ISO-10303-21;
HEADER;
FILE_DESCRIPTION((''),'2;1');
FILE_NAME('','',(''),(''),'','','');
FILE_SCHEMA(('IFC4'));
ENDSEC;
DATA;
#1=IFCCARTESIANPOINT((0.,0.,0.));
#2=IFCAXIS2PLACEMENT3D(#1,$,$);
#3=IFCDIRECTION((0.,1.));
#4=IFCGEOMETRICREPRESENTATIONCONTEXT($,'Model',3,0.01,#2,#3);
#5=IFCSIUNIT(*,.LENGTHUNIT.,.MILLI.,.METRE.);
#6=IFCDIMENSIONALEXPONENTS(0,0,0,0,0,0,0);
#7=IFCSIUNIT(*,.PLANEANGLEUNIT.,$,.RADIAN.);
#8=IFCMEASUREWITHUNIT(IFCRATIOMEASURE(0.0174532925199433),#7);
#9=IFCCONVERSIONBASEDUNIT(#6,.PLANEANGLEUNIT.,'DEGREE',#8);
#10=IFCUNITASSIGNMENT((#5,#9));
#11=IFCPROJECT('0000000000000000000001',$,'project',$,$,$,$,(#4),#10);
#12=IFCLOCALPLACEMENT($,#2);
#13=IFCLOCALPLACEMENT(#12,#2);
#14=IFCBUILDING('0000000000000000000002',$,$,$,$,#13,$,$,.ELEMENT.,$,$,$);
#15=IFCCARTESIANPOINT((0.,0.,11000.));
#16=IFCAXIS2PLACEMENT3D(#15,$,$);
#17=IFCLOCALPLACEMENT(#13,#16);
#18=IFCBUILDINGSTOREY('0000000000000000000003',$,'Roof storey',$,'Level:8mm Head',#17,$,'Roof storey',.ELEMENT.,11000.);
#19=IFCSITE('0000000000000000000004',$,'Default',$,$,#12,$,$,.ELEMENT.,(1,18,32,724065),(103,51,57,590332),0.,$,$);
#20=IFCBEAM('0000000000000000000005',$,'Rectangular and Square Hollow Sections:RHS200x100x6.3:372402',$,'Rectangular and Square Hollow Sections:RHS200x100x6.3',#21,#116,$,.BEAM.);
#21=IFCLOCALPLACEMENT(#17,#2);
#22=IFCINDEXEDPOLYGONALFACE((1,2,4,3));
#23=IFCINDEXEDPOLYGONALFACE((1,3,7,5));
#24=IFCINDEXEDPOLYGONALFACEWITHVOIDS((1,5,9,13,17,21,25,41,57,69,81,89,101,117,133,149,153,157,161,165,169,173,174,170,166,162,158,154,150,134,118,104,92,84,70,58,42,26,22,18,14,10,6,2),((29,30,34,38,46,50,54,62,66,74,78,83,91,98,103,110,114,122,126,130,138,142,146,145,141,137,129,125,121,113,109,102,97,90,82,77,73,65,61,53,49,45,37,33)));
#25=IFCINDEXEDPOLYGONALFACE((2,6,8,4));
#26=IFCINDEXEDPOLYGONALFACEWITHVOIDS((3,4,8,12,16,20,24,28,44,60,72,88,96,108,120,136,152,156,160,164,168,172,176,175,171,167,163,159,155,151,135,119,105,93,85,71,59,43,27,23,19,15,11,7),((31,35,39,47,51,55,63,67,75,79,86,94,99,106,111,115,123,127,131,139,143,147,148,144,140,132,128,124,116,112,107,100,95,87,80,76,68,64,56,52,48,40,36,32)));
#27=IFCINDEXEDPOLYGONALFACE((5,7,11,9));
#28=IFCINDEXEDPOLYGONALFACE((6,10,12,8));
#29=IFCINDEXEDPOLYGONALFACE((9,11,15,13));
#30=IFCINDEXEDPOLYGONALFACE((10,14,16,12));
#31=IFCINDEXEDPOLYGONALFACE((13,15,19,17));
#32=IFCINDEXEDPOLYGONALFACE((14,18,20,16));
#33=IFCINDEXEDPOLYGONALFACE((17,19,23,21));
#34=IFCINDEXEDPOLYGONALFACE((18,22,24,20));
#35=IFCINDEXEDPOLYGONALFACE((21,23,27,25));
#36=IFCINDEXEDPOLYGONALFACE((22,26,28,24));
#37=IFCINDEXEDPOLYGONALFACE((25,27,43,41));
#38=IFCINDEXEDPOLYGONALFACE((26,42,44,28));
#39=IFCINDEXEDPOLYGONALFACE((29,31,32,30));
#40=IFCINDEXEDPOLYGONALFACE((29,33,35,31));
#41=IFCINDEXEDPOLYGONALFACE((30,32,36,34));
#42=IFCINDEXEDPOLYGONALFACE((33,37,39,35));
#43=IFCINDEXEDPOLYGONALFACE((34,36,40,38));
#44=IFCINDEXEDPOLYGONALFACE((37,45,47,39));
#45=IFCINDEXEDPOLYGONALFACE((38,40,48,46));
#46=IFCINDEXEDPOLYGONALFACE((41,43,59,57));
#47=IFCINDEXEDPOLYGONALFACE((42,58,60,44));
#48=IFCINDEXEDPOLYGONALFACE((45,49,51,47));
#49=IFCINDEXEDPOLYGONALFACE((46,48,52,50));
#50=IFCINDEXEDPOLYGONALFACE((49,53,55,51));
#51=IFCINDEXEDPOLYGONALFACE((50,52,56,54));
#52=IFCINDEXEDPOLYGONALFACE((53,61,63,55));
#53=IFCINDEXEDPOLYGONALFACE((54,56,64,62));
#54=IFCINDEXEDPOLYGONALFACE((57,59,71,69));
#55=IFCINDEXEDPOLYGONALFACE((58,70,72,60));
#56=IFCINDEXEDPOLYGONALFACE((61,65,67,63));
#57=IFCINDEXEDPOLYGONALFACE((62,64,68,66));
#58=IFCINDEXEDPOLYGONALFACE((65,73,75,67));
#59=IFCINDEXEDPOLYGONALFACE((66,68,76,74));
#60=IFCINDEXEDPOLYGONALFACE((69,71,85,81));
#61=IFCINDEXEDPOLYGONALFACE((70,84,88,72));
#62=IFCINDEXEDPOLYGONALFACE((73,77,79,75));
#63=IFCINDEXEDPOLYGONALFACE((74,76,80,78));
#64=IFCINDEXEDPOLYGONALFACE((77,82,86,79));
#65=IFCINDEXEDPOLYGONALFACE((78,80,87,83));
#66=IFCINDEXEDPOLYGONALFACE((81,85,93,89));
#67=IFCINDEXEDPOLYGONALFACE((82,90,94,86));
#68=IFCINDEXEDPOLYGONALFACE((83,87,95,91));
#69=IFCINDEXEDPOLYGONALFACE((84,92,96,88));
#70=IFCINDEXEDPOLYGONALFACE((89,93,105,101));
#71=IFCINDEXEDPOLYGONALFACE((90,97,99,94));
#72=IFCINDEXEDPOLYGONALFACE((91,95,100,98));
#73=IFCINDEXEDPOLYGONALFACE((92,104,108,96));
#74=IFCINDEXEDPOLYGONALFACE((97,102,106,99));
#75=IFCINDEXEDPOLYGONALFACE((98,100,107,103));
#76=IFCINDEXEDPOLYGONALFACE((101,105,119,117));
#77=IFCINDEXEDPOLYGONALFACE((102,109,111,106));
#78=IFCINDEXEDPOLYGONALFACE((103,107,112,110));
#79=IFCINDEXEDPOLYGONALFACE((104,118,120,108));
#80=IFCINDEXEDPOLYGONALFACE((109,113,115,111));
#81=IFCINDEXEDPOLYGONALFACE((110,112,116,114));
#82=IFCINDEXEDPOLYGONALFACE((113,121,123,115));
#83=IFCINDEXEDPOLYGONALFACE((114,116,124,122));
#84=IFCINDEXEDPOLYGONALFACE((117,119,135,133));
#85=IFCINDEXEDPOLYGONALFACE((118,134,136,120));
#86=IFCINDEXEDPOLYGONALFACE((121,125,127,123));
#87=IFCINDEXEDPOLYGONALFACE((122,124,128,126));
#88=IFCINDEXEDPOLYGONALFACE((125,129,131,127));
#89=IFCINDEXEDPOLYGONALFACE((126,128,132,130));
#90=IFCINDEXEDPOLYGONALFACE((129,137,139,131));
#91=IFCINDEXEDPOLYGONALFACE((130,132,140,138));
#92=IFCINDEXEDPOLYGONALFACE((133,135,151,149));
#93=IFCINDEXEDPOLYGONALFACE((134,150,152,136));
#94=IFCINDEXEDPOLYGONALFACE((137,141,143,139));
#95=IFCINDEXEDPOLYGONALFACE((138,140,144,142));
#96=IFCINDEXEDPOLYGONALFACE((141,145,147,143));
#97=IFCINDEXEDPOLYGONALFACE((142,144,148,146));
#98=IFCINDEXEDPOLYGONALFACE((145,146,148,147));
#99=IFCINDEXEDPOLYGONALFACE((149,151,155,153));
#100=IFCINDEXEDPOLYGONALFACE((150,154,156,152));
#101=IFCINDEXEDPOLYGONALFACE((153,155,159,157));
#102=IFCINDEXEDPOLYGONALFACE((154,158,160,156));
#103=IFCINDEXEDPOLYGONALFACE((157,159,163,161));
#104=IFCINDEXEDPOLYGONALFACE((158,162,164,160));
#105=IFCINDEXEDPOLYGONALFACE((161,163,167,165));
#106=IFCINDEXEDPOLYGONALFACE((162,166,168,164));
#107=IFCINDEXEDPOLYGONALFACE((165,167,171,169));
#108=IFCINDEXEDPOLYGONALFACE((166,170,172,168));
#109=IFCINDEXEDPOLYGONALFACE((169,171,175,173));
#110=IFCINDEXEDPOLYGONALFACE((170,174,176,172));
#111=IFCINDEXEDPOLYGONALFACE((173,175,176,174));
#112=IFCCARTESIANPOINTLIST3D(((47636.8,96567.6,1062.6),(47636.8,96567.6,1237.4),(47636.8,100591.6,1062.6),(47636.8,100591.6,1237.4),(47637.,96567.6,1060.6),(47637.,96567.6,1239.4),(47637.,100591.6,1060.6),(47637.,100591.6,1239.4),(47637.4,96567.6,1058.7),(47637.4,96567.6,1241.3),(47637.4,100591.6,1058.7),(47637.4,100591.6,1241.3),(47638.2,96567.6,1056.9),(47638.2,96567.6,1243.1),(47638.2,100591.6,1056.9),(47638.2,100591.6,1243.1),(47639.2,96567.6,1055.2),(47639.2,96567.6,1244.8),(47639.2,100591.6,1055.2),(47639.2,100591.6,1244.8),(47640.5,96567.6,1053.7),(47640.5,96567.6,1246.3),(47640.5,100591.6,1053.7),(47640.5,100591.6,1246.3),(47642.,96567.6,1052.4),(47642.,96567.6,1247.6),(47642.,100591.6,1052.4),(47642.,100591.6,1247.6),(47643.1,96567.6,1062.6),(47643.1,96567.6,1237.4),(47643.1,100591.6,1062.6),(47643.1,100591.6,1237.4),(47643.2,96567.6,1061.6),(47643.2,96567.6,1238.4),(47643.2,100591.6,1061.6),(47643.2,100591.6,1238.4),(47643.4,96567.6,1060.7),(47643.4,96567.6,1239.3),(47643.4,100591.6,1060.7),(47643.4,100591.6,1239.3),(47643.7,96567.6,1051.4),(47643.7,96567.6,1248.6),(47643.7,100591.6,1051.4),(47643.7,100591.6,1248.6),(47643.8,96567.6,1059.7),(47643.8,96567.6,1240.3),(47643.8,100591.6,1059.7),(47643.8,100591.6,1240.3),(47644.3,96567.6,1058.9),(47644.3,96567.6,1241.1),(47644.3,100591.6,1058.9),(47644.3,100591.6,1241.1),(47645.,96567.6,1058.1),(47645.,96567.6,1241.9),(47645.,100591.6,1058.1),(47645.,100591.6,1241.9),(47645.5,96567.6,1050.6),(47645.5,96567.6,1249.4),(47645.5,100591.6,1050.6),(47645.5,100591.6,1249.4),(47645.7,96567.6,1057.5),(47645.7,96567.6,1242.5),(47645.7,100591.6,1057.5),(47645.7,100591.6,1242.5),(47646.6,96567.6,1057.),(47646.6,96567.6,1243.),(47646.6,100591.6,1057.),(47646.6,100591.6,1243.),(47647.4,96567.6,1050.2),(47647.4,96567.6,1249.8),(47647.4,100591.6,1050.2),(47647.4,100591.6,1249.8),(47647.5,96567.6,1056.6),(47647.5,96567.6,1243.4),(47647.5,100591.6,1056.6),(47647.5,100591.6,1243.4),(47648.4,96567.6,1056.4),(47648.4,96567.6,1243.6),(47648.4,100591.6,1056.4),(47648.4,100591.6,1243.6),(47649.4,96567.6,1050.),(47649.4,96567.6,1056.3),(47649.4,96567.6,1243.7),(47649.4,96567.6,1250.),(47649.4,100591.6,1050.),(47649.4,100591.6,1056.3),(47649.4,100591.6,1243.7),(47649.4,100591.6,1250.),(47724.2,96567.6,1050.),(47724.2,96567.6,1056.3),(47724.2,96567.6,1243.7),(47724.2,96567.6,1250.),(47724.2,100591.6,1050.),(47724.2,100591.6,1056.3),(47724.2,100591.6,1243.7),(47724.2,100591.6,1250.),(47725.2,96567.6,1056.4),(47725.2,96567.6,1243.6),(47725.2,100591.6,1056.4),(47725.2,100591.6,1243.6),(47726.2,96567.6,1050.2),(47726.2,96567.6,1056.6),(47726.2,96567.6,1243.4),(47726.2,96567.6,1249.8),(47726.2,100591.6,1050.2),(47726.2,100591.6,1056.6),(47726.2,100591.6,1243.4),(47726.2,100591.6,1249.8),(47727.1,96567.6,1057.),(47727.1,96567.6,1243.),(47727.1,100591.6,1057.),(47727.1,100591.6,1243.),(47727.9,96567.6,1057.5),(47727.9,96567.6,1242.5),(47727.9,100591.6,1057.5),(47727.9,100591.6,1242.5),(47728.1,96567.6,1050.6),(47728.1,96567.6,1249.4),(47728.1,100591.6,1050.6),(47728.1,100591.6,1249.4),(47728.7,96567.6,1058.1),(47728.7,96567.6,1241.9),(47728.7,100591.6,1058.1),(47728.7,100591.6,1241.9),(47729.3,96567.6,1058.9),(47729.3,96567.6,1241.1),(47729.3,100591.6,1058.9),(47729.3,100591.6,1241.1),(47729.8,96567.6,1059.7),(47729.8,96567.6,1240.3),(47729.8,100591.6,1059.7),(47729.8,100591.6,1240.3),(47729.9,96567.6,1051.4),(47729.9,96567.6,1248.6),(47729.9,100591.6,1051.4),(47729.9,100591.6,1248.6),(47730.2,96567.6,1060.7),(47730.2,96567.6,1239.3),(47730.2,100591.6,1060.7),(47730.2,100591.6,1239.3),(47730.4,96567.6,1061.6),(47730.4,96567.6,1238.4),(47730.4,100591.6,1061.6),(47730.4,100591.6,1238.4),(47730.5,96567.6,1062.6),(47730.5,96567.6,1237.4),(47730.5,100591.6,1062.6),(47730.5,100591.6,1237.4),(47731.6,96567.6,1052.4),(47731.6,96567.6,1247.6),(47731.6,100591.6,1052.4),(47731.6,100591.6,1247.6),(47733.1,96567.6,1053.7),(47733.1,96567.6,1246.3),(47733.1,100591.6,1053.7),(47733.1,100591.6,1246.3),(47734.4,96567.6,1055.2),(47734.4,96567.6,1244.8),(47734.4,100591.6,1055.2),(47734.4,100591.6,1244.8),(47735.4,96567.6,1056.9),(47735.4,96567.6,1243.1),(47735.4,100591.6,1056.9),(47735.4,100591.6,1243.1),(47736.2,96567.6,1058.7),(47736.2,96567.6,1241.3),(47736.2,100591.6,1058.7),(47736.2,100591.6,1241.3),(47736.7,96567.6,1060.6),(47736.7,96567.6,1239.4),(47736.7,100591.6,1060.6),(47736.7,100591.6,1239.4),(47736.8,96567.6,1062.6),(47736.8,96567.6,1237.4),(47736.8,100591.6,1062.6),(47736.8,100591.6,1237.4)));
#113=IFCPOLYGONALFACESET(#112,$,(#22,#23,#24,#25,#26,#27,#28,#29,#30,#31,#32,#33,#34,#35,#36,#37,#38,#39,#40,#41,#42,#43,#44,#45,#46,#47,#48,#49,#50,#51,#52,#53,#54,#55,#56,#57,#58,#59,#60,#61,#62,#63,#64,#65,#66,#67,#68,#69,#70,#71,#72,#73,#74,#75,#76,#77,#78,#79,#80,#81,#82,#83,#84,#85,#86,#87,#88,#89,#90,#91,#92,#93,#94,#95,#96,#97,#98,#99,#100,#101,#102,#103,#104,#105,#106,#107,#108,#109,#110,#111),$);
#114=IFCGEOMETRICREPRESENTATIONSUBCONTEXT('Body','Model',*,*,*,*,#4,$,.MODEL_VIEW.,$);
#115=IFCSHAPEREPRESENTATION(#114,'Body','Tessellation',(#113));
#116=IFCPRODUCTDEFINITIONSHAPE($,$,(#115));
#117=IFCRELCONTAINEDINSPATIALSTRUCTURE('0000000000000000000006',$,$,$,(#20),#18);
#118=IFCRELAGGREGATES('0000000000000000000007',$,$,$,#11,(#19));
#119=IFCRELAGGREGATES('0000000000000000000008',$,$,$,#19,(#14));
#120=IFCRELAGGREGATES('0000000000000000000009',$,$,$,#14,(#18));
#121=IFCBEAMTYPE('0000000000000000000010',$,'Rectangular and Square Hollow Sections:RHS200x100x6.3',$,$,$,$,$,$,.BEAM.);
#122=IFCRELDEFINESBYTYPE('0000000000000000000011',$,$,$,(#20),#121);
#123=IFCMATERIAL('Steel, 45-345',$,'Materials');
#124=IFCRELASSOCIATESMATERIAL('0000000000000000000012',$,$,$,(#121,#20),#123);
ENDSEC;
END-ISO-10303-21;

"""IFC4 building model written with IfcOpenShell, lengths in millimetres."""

from ifc_helpers import new_model, entity, si_unit, converted_unit, direction, frame, origin, place, context, subcontext, project, spatial, indexed_curve, outline, extrude, source, transform, mapped, material, type_object, type_shapes, element, save


model = new_model("IFC4")

# Units and contexts
model_context = context("Model", 3, precision=0.01, world=origin(), true_north=direction((0.0, 1.0)))
body_context = subcontext(model_context, "Body", "Model", "MODEL_VIEW")
ifc_project = project(units=[si_unit("LENGTHUNIT", "METRE", prefix="MILLI"), converted_unit("PLANEANGLEUNIT", "DEGREE", entity("IfcRatioMeasure", 0.0174532925199433), si_unit("PLANEANGLEUNIT", "RADIAN"), dimensions=[0, 0, 0, 0, 0, 0, 0])], contexts=[model_context])

# Site, building, storey
site_placement = place(None, origin())
site = spatial("IfcSite", under=ifc_project, at=site_placement, Name="Default", CompositionType="ELEMENT", RefLatitude=(1, 18, 32, 724065), RefLongitude=(103, 51, 57, 590332), RefElevation=0.0)
building_placement = place(site_placement, origin())
building = spatial("IfcBuilding", under=site, at=building_placement, CompositionType="ELEMENT")
storey_placement = place(building_placement, frame((0.0, 0.0, 11000.0)))
storey = spatial("IfcBuildingStorey", under=building, at=storey_placement, Name="Roof storey", ObjectType="Level:8mm Head", LongName="Roof storey", CompositionType="ELEMENT", Elevation=11000.0)

# Shared definitions
ifc_material = material(Name="Steel, 45-345", Category="Materials")

# Beam
beam_type_1 = type_object("IfcBeamType", Name="Rectangular and Square Hollow Sections:RHS200x100x6.3", PredefinedType="BEAM", material=ifc_material)
shared_shape_1 = source(origin(), body_context, "Body", "SweptSolid", [
    extrude(outline(indexed_curve([(87.4, -50.0), (89.4, -49.8), (91.3, -49.4), (93.1, -48.6), (94.8, -47.6), (96.3, -46.3), (97.6, -44.8), (98.6, -43.1), (99.4, -41.3), (99.8, -39.4), (100.0, -37.4), (100.0, 37.4), (99.8, 39.4), (99.4, 41.3), (98.6, 43.1), (97.6, 44.8), (96.3, 46.3), (94.8, 47.6), (93.1, 48.6), (91.3, 49.4), (89.4, 49.8), (87.4, 50.0), (-87.4, 50.0), (-89.4, 49.8), (-91.3, 49.4), (-93.1, 48.6), (-94.8, 47.6), (-96.3, 46.3), (-97.6, 44.8), (-98.6, 43.1), (-99.4, 41.3), (-99.8, 39.4), (-100.0, 37.4), (-100.0, -37.4), (-99.8, -39.4), (-99.4, -41.3), (-98.6, -43.1), (-97.6, -44.8), (-96.3, -46.3), (-94.8, -47.6), (-93.1, -48.6), (-91.3, -49.4), (-89.4, -49.8), (-87.4, -50.0), (87.4, -50.0)], self_intersect=False), holes=[indexed_curve([(93.7, 37.4), (93.7, -37.4), (93.6, -38.4), (93.4, -39.3), (93.0, -40.3), (92.5, -41.1), (91.9, -41.9), (91.1, -42.5), (90.3, -43.0), (89.3, -43.4), (88.4, -43.6), (87.4, -43.7), (-87.4, -43.7), (-88.4, -43.6), (-89.3, -43.4), (-90.3, -43.0), (-91.1, -42.5), (-91.9, -41.9), (-92.5, -41.1), (-93.0, -40.3), (-93.4, -39.3), (-93.6, -38.4), (-93.7, -37.4), (-93.7, 37.4), (-93.6, 38.4), (-93.4, 39.3), (-93.0, 40.3), (-92.5, 41.1), (-91.9, 41.9), (-91.1, 42.5), (-90.3, 43.0), (-89.3, 43.4), (-88.4, 43.6), (-87.4, 43.7), (87.4, 43.7), (88.4, 43.6), (89.3, 43.4), (90.3, 43.0), (91.1, 42.5), (91.9, 41.9), (92.5, 41.1), (93.0, 40.3), (93.4, 39.3), (93.6, 38.4), (93.7, 37.4)], self_intersect=False)]), frame((-2012.0, 0.0, 0.0), z_axis=(1.0, 0.0, 0.0), x_axis=(0.0, 0.0, 1.0)), (0.0, 0.0, 1.0), 4024.0),
])
type_shapes(beam_type_1, [shared_shape_1])
for number, where, z_axis, x_axis, name in (
    (1, (47686.8, 98579.6, 1150.0), (0.0, 0.0, 1.0), (0.0, 1.0, 0.0), "Rectangular and Square Hollow Sections:RHS200x100x6.3:372402"),
):
    element("IfcBeam", number, at=place(storey_placement, frame(where, z_axis=z_axis, x_axis=x_axis)), inside=storey, type_object=beam_type_1, material=ifc_material, Name=name, ObjectType="Rectangular and Square Hollow Sections:RHS200x100x6.3", PredefinedType="BEAM", context=body_context, shape_type="MappedRepresentation", body=[
        mapped(shared_shape_1, transform((0.0, 0.0, 0.0), scale=1.0)),
    ])

save(model, "model.ifc")
